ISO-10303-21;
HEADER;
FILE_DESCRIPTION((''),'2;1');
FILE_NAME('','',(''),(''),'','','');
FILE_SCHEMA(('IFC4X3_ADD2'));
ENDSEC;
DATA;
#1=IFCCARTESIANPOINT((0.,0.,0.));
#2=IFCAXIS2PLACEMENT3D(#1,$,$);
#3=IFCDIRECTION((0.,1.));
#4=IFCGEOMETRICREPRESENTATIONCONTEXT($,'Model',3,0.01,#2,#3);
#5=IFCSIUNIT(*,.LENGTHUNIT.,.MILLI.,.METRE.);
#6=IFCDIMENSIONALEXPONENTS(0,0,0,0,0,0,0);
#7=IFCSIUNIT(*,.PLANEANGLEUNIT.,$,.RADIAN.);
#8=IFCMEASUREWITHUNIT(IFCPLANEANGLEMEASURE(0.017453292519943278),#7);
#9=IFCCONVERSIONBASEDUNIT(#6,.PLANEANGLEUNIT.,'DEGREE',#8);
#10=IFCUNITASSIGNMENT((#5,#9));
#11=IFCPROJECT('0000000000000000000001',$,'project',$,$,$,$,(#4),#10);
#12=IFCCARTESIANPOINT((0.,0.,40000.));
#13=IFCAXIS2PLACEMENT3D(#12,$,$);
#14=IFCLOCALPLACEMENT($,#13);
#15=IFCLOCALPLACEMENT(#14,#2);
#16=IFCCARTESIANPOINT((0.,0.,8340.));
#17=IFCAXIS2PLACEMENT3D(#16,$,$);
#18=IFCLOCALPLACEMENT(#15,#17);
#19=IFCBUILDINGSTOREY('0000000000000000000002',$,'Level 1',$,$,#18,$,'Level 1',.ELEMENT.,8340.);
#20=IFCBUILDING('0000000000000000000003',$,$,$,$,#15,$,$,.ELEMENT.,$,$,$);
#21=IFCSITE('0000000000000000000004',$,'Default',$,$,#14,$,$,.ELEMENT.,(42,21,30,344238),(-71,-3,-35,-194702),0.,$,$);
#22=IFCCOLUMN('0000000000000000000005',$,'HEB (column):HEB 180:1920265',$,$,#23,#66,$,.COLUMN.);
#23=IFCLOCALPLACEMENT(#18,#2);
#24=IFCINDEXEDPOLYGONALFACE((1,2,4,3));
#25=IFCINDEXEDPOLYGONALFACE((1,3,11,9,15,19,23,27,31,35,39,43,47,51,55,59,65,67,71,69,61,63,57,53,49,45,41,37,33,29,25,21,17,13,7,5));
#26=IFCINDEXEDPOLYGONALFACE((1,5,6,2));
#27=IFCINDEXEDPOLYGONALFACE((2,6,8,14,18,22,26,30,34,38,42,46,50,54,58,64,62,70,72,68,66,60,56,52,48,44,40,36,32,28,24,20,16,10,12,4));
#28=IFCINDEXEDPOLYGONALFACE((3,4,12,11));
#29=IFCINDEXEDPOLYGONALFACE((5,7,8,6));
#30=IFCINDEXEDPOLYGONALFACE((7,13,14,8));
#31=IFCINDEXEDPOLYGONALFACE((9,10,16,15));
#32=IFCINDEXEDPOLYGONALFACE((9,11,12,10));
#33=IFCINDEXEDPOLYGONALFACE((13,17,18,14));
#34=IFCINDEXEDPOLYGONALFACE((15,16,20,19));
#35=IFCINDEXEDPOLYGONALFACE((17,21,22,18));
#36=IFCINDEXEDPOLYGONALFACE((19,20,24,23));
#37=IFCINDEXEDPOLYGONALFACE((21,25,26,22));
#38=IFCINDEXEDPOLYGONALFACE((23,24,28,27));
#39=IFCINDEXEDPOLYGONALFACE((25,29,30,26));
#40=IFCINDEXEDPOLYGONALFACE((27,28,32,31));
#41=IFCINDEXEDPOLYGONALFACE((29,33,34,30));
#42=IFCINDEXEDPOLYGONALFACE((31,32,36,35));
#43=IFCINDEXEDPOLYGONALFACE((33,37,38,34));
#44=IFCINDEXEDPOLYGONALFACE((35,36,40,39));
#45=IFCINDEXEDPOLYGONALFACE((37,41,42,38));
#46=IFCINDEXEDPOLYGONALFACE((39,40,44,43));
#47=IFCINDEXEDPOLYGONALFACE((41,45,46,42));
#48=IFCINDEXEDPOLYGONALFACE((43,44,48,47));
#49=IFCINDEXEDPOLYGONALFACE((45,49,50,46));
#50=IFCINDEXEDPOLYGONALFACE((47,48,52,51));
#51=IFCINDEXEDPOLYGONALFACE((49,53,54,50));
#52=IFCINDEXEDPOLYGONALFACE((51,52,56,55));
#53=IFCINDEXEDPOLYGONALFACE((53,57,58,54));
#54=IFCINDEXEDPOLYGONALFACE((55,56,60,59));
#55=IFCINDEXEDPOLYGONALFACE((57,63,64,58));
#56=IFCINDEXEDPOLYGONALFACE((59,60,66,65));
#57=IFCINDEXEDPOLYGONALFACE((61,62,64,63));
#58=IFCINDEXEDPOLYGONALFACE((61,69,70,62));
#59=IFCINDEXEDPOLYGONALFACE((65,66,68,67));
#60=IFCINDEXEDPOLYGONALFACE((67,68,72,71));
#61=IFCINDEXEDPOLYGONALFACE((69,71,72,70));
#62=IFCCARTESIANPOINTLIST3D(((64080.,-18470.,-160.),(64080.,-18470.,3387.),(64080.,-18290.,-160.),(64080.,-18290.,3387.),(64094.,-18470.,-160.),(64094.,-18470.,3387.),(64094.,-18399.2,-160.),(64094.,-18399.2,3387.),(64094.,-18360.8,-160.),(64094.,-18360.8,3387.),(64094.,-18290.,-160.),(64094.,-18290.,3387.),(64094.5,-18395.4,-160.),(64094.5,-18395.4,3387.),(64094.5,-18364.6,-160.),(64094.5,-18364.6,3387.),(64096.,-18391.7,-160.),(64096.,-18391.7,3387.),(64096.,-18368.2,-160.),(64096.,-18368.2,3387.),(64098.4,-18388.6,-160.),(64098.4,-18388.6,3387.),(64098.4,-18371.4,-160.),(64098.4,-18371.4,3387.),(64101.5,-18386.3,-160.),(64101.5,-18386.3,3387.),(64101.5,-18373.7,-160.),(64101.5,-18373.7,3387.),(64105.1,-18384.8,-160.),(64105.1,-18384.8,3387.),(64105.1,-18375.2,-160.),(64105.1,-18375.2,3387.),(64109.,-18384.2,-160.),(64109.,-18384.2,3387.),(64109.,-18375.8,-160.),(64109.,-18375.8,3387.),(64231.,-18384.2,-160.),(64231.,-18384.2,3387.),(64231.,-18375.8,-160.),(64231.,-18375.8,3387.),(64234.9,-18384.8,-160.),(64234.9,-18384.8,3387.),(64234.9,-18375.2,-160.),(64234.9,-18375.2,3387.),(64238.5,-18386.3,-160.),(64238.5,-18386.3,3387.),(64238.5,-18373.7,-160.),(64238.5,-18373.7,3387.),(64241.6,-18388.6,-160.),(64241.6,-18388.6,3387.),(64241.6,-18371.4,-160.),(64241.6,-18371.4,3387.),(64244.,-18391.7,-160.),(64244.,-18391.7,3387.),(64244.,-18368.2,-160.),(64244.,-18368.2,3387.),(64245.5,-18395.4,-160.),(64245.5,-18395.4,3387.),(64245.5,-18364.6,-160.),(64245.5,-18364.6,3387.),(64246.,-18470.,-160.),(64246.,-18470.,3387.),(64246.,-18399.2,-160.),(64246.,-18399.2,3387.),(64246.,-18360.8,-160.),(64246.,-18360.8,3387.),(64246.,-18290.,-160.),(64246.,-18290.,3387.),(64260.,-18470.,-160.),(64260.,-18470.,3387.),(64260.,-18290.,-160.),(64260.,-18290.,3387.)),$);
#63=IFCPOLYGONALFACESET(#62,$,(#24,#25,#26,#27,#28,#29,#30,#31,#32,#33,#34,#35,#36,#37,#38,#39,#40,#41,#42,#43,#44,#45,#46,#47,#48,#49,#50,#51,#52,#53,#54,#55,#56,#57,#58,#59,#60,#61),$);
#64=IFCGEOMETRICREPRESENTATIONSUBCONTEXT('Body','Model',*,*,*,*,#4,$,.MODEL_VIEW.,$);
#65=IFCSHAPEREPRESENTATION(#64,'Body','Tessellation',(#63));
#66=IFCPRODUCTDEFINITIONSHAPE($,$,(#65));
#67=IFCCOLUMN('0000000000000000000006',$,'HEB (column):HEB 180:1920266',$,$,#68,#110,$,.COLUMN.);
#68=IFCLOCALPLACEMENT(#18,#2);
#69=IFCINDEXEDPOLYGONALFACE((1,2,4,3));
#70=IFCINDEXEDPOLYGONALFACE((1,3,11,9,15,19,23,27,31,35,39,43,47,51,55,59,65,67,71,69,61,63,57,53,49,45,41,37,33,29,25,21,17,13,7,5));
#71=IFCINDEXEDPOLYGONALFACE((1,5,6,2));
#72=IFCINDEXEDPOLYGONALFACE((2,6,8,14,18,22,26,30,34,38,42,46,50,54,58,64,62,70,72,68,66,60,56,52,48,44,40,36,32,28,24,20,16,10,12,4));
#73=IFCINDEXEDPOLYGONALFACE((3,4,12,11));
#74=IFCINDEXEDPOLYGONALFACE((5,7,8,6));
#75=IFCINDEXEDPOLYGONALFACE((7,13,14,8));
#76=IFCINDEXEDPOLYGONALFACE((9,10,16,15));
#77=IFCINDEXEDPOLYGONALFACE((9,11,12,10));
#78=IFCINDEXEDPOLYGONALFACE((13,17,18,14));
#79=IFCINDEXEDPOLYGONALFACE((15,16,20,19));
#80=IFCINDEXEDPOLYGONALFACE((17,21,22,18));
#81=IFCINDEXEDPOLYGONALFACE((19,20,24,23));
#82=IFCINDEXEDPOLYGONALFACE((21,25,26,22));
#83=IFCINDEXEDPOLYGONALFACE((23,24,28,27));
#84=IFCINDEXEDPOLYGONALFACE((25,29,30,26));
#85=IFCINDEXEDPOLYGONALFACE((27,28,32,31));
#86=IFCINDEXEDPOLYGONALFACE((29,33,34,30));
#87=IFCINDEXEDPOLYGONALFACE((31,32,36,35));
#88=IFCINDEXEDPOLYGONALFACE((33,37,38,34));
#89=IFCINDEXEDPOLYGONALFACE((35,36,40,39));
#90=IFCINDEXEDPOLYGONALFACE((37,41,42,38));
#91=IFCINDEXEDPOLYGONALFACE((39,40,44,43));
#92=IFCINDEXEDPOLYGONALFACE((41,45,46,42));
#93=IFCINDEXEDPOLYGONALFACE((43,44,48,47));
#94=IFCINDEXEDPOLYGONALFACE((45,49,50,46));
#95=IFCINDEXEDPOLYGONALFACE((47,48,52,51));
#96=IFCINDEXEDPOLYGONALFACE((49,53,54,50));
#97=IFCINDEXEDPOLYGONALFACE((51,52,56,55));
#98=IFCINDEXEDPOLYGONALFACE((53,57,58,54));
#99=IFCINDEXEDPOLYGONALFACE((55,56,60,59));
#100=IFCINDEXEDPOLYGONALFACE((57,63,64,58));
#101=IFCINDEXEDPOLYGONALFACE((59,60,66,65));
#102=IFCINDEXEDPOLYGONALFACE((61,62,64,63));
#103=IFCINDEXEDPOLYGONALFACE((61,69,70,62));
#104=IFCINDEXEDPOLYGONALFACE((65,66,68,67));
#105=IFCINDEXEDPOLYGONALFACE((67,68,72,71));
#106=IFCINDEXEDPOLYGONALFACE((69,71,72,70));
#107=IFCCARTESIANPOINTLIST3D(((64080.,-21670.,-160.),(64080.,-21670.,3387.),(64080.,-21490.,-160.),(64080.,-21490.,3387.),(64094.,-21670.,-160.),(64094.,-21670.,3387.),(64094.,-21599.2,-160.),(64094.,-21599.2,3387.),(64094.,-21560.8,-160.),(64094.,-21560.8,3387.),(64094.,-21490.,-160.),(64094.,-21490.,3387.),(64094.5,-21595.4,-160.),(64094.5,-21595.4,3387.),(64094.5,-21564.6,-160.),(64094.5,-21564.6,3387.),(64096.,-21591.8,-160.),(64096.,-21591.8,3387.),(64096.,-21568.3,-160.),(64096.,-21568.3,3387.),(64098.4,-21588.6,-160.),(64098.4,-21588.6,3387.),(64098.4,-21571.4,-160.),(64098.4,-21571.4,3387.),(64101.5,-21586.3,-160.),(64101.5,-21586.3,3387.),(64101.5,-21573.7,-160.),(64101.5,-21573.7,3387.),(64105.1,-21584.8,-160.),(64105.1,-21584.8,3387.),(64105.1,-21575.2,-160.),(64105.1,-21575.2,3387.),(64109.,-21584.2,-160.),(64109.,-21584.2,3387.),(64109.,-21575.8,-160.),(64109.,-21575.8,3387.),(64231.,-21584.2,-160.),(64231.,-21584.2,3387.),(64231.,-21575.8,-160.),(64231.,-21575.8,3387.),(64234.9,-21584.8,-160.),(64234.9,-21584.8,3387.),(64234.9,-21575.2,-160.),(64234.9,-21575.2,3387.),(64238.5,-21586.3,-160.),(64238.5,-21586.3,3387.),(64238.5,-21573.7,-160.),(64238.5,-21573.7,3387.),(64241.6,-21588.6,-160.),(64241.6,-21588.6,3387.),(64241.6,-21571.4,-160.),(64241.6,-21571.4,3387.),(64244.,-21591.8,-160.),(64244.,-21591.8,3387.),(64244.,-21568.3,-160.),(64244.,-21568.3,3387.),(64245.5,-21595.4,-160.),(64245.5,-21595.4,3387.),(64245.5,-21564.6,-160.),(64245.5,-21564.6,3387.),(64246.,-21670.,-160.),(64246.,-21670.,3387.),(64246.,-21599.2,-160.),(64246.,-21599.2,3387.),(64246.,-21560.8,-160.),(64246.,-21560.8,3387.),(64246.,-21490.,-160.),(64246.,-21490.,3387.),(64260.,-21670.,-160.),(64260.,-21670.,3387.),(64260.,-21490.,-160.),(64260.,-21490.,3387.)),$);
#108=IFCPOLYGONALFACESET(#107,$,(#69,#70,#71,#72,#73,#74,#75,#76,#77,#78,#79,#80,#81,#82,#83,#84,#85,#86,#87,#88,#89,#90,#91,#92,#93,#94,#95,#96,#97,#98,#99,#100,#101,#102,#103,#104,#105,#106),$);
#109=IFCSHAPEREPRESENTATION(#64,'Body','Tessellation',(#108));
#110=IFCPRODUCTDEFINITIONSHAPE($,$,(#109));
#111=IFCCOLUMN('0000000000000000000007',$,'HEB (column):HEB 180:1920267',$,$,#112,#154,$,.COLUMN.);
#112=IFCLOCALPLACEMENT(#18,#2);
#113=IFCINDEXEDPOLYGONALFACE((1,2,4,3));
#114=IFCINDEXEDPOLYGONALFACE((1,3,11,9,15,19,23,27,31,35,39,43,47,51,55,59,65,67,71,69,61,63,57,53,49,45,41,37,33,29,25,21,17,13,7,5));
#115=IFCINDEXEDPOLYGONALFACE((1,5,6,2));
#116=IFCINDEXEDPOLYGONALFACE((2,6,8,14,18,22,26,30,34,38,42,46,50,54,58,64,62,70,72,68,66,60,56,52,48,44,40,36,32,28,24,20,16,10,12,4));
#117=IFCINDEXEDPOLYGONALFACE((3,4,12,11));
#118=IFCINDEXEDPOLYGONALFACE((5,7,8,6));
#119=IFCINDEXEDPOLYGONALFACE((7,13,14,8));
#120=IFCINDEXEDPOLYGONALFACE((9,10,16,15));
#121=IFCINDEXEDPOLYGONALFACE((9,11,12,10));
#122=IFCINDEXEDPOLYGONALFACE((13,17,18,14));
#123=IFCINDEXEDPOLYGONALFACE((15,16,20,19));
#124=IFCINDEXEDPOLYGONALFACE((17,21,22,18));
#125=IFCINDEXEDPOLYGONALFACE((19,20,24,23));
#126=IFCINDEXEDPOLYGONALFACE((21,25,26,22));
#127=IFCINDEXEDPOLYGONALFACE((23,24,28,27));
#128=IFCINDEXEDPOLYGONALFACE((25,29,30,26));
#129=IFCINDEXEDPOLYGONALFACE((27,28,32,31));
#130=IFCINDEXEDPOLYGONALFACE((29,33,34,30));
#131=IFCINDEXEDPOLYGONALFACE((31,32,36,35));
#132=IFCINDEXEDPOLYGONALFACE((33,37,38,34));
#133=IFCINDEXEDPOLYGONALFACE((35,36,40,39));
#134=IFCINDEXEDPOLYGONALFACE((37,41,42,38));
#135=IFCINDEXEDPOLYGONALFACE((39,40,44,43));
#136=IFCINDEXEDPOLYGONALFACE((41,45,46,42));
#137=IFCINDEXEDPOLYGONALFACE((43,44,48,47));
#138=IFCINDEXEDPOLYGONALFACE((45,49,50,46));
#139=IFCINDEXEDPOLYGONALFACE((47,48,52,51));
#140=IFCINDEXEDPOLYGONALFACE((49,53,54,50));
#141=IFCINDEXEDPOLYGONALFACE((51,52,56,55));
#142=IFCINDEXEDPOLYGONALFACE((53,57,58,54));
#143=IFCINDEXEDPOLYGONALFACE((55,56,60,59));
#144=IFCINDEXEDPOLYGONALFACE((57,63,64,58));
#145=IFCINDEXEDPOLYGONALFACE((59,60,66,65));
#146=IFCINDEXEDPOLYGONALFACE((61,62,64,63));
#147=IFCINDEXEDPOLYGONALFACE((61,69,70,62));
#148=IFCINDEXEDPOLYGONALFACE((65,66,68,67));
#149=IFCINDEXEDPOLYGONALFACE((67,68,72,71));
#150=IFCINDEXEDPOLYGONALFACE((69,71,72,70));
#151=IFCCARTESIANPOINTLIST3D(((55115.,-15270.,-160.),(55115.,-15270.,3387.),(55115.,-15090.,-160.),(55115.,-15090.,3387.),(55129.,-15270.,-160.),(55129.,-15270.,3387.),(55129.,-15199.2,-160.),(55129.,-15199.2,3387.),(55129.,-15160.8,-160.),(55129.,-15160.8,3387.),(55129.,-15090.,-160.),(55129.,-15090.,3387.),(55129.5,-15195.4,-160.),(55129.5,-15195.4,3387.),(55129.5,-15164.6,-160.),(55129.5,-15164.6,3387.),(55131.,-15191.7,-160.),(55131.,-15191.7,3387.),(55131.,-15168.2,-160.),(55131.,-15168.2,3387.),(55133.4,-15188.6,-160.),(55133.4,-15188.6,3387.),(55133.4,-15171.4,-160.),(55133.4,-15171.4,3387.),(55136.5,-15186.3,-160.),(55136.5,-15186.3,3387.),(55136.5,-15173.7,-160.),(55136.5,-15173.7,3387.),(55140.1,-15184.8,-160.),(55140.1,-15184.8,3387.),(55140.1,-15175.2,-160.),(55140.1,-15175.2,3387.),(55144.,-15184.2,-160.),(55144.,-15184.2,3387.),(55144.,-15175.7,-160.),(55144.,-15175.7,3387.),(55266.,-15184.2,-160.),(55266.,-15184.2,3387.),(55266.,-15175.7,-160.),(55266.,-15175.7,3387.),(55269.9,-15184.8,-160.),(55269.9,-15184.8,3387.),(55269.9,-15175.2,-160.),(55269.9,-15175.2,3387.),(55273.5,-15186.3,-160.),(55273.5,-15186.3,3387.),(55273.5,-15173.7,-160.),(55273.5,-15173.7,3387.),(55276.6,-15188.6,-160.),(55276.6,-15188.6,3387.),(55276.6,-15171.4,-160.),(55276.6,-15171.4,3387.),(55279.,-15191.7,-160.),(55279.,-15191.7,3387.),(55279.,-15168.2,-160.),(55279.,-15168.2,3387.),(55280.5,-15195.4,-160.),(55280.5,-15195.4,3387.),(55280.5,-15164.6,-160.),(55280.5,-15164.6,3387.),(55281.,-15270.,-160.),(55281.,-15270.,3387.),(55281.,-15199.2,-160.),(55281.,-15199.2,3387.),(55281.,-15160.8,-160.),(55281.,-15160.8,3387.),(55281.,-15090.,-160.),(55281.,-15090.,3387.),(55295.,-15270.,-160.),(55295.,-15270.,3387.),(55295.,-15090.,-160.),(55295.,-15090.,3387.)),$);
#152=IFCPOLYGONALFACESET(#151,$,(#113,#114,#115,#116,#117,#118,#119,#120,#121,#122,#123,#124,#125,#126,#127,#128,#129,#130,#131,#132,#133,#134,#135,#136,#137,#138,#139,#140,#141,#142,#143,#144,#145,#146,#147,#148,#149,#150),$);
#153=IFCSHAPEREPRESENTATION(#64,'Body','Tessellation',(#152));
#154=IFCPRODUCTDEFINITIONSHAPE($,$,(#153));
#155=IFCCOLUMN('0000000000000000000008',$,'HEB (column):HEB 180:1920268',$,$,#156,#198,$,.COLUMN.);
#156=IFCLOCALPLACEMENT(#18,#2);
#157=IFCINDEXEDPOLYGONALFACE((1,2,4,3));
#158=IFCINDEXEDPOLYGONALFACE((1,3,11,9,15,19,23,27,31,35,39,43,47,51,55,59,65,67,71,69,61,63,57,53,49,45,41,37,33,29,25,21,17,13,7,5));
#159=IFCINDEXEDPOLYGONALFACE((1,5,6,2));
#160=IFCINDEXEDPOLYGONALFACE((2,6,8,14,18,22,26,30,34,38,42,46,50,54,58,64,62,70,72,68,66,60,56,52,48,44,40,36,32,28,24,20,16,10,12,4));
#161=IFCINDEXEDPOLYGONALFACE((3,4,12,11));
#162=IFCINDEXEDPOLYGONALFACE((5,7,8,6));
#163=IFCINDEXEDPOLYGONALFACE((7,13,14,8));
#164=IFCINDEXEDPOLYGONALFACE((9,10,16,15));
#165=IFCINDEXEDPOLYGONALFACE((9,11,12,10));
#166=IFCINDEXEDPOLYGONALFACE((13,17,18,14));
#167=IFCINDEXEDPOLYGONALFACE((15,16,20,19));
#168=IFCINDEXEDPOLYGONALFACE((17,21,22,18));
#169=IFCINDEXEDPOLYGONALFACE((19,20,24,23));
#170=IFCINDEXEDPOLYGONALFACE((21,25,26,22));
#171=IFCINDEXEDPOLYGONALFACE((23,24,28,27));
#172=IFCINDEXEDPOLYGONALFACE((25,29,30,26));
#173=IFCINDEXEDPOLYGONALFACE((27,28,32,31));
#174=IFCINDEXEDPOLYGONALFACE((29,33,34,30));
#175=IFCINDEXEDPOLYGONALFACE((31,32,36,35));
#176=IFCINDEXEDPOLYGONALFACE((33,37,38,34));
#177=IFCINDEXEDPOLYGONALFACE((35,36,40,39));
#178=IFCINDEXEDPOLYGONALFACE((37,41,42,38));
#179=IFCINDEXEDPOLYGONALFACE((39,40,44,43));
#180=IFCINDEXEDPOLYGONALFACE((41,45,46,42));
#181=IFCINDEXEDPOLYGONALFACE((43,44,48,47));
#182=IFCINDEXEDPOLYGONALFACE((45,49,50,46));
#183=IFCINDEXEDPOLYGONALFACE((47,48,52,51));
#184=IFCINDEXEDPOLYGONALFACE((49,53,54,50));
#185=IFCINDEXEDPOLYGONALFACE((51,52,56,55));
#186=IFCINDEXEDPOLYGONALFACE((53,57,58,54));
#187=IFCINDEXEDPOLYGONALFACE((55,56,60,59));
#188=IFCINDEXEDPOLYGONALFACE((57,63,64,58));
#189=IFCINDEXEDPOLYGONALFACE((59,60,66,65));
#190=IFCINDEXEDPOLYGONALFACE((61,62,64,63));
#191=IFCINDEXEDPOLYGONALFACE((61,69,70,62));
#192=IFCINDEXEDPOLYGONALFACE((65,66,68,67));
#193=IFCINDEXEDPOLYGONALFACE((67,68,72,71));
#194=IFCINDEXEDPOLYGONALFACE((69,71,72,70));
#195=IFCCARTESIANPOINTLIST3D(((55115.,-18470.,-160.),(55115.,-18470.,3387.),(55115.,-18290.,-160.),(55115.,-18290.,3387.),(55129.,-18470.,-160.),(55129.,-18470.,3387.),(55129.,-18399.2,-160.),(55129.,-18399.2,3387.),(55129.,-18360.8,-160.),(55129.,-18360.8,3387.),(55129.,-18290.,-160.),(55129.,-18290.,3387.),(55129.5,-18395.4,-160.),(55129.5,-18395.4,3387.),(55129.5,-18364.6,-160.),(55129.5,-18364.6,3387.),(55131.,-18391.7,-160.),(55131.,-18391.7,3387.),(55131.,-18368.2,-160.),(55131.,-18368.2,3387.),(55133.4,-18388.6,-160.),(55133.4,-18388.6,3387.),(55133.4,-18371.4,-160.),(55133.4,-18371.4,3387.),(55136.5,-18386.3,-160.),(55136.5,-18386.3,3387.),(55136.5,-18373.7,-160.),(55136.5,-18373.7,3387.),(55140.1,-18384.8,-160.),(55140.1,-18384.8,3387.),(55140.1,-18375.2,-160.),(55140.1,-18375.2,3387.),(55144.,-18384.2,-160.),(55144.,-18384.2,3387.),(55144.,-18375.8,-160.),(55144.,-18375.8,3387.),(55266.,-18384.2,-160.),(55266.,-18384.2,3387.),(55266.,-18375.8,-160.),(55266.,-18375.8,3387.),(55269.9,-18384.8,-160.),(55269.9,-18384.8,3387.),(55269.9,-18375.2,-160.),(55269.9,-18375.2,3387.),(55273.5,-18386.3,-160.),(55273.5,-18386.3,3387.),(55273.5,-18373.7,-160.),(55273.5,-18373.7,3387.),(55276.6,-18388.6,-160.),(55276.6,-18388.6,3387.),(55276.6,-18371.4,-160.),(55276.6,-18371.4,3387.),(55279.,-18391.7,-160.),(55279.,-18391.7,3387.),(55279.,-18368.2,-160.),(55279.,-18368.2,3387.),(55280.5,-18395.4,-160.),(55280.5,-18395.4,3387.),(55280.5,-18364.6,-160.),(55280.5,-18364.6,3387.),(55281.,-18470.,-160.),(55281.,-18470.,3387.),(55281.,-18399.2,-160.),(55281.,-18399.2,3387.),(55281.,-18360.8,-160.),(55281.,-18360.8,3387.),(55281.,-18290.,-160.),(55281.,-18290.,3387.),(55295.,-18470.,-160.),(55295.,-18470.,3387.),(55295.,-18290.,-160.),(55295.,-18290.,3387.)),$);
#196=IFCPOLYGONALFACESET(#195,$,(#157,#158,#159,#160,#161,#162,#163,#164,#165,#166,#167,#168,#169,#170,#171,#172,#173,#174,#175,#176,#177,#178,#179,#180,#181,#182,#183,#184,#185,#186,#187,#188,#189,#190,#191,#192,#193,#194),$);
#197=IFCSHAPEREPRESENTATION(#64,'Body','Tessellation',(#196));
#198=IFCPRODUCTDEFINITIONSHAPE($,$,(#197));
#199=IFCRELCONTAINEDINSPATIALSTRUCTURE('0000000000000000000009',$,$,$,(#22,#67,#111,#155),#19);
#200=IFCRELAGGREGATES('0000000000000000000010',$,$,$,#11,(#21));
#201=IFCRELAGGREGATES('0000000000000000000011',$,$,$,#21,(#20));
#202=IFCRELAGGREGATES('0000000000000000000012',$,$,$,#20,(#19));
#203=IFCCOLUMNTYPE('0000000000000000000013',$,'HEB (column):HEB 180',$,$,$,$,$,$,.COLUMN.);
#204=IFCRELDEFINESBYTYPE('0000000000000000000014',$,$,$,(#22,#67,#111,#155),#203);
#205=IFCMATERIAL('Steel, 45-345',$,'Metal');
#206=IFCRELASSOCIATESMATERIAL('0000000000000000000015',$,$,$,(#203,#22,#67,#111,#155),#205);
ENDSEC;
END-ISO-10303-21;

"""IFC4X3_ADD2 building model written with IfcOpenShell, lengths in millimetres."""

from ifc_helpers import new_model, entity, si_unit, converted_unit, direction, frame, origin, origin_2d_with_axis, place, context, subcontext, project, spatial, i_section, extrude, source, transform, mapped, material, material_profile, profile_set, profile_usage, type_object, type_shapes, element, save


model = new_model("IFC4X3_ADD2")

# Units and contexts
model_context = context("Model", 3, precision=0.01, world=origin(), true_north=direction((0.0, 1.0)))
body_context = subcontext(model_context, "Body", "Model", "MODEL_VIEW")
ifc_project = project(units=[si_unit("LENGTHUNIT", "METRE", prefix="MILLI"), converted_unit("PLANEANGLEUNIT", "DEGREE", entity("IfcPlaneAngleMeasure", 0.017453292519943278), si_unit("PLANEANGLEUNIT", "RADIAN"), dimensions=[0, 0, 0, 0, 0, 0, 0])], contexts=[model_context])

# Site, building, storey
site_placement = place(None, frame((0.0, 0.0, 40000.0)))
site = spatial("IfcSite", under=ifc_project, at=site_placement, Name="Default", CompositionType="ELEMENT", RefLatitude=(42, 21, 30, 344238), RefLongitude=(-71, -3, -35, -194702), RefElevation=0.0)
building_placement = place(site_placement, origin())
building = spatial("IfcBuilding", under=site, at=building_placement, CompositionType="ELEMENT")
storey_placement = place(building_placement, frame((0.0, 0.0, 8340.0)))
storey = spatial("IfcBuildingStorey", under=building, at=storey_placement, Name="Level 1", LongName="Level 1", CompositionType="ELEMENT", Elevation=8340.0)

# Columns
ifc_material_1 = material(Name="Steel, 45-345", Category="Metal")
ifc_material_profile_1 = material_profile(ifc_material_1, i_section(OverallWidth=180.0, OverallDepth=180.0, WebThickness=8.5, FlangeThickness=14.0, FilletRadius=15.0, at=origin_2d_with_axis()), Name="HEB 180")
ifc_profile_set_1 = profile_set([ifc_material_profile_1], Name="HEB 180")
ifc_profile_usage_1 = profile_usage(ifc_profile_set_1)
column_type_1 = type_object("IfcColumnType", Name="HEB (column):HEB 180", PredefinedType="COLUMN", material=ifc_profile_set_1)
shared_shape_1 = source(origin(), body_context, "Body", "SweptSolid", [
    extrude(i_section(OverallWidth=180.0, OverallDepth=180.0, WebThickness=8.5, FlangeThickness=14.0, FilletRadius=15.0, at=origin_2d_with_axis()), frame((0.0, 0.0, 8180.0), z_axis=(0.0, 0.0, 1.0), x_axis=(-1.0, 0.0, 0.0)), (0.0, 0.0, 1.0), 3547.0),
])
type_shapes(column_type_1, [shared_shape_1])
for number, where, z_axis, x_axis, name in (
    (1, (64170.0, -18380.0, -8340.0), (0.0, 0.0, 1.0), (0.0, -1.0, 0.0), "HEB (column):HEB 180:1920265"),
    (2, (64170.0, -21580.0, -8340.0), (0.0, 0.0, 1.0), (0.0, -1.0, 0.0), "HEB (column):HEB 180:1920266"),
    (3, (55205.0, -15180.0, -8340.0), (0.0, 0.0, 1.0), (0.0, -1.0, 0.0), "HEB (column):HEB 180:1920267"),
    (4, (55205.0, -18380.0, -8340.0), (0.0, 0.0, 1.0), (0.0, -1.0, 0.0), "HEB (column):HEB 180:1920268"),
):
    element("IfcColumn", number, at=place(storey_placement, frame(where, z_axis=z_axis, x_axis=x_axis)), inside=storey, type_object=column_type_1, material=ifc_profile_usage_1, Name=name, PredefinedType="COLUMN", context=body_context, shape_type="MappedRepresentation", body=[
        mapped(shared_shape_1, transform((0.0, 0.0, 0.0), scale=1.0)),
    ])

save(model, "model.ifc")
